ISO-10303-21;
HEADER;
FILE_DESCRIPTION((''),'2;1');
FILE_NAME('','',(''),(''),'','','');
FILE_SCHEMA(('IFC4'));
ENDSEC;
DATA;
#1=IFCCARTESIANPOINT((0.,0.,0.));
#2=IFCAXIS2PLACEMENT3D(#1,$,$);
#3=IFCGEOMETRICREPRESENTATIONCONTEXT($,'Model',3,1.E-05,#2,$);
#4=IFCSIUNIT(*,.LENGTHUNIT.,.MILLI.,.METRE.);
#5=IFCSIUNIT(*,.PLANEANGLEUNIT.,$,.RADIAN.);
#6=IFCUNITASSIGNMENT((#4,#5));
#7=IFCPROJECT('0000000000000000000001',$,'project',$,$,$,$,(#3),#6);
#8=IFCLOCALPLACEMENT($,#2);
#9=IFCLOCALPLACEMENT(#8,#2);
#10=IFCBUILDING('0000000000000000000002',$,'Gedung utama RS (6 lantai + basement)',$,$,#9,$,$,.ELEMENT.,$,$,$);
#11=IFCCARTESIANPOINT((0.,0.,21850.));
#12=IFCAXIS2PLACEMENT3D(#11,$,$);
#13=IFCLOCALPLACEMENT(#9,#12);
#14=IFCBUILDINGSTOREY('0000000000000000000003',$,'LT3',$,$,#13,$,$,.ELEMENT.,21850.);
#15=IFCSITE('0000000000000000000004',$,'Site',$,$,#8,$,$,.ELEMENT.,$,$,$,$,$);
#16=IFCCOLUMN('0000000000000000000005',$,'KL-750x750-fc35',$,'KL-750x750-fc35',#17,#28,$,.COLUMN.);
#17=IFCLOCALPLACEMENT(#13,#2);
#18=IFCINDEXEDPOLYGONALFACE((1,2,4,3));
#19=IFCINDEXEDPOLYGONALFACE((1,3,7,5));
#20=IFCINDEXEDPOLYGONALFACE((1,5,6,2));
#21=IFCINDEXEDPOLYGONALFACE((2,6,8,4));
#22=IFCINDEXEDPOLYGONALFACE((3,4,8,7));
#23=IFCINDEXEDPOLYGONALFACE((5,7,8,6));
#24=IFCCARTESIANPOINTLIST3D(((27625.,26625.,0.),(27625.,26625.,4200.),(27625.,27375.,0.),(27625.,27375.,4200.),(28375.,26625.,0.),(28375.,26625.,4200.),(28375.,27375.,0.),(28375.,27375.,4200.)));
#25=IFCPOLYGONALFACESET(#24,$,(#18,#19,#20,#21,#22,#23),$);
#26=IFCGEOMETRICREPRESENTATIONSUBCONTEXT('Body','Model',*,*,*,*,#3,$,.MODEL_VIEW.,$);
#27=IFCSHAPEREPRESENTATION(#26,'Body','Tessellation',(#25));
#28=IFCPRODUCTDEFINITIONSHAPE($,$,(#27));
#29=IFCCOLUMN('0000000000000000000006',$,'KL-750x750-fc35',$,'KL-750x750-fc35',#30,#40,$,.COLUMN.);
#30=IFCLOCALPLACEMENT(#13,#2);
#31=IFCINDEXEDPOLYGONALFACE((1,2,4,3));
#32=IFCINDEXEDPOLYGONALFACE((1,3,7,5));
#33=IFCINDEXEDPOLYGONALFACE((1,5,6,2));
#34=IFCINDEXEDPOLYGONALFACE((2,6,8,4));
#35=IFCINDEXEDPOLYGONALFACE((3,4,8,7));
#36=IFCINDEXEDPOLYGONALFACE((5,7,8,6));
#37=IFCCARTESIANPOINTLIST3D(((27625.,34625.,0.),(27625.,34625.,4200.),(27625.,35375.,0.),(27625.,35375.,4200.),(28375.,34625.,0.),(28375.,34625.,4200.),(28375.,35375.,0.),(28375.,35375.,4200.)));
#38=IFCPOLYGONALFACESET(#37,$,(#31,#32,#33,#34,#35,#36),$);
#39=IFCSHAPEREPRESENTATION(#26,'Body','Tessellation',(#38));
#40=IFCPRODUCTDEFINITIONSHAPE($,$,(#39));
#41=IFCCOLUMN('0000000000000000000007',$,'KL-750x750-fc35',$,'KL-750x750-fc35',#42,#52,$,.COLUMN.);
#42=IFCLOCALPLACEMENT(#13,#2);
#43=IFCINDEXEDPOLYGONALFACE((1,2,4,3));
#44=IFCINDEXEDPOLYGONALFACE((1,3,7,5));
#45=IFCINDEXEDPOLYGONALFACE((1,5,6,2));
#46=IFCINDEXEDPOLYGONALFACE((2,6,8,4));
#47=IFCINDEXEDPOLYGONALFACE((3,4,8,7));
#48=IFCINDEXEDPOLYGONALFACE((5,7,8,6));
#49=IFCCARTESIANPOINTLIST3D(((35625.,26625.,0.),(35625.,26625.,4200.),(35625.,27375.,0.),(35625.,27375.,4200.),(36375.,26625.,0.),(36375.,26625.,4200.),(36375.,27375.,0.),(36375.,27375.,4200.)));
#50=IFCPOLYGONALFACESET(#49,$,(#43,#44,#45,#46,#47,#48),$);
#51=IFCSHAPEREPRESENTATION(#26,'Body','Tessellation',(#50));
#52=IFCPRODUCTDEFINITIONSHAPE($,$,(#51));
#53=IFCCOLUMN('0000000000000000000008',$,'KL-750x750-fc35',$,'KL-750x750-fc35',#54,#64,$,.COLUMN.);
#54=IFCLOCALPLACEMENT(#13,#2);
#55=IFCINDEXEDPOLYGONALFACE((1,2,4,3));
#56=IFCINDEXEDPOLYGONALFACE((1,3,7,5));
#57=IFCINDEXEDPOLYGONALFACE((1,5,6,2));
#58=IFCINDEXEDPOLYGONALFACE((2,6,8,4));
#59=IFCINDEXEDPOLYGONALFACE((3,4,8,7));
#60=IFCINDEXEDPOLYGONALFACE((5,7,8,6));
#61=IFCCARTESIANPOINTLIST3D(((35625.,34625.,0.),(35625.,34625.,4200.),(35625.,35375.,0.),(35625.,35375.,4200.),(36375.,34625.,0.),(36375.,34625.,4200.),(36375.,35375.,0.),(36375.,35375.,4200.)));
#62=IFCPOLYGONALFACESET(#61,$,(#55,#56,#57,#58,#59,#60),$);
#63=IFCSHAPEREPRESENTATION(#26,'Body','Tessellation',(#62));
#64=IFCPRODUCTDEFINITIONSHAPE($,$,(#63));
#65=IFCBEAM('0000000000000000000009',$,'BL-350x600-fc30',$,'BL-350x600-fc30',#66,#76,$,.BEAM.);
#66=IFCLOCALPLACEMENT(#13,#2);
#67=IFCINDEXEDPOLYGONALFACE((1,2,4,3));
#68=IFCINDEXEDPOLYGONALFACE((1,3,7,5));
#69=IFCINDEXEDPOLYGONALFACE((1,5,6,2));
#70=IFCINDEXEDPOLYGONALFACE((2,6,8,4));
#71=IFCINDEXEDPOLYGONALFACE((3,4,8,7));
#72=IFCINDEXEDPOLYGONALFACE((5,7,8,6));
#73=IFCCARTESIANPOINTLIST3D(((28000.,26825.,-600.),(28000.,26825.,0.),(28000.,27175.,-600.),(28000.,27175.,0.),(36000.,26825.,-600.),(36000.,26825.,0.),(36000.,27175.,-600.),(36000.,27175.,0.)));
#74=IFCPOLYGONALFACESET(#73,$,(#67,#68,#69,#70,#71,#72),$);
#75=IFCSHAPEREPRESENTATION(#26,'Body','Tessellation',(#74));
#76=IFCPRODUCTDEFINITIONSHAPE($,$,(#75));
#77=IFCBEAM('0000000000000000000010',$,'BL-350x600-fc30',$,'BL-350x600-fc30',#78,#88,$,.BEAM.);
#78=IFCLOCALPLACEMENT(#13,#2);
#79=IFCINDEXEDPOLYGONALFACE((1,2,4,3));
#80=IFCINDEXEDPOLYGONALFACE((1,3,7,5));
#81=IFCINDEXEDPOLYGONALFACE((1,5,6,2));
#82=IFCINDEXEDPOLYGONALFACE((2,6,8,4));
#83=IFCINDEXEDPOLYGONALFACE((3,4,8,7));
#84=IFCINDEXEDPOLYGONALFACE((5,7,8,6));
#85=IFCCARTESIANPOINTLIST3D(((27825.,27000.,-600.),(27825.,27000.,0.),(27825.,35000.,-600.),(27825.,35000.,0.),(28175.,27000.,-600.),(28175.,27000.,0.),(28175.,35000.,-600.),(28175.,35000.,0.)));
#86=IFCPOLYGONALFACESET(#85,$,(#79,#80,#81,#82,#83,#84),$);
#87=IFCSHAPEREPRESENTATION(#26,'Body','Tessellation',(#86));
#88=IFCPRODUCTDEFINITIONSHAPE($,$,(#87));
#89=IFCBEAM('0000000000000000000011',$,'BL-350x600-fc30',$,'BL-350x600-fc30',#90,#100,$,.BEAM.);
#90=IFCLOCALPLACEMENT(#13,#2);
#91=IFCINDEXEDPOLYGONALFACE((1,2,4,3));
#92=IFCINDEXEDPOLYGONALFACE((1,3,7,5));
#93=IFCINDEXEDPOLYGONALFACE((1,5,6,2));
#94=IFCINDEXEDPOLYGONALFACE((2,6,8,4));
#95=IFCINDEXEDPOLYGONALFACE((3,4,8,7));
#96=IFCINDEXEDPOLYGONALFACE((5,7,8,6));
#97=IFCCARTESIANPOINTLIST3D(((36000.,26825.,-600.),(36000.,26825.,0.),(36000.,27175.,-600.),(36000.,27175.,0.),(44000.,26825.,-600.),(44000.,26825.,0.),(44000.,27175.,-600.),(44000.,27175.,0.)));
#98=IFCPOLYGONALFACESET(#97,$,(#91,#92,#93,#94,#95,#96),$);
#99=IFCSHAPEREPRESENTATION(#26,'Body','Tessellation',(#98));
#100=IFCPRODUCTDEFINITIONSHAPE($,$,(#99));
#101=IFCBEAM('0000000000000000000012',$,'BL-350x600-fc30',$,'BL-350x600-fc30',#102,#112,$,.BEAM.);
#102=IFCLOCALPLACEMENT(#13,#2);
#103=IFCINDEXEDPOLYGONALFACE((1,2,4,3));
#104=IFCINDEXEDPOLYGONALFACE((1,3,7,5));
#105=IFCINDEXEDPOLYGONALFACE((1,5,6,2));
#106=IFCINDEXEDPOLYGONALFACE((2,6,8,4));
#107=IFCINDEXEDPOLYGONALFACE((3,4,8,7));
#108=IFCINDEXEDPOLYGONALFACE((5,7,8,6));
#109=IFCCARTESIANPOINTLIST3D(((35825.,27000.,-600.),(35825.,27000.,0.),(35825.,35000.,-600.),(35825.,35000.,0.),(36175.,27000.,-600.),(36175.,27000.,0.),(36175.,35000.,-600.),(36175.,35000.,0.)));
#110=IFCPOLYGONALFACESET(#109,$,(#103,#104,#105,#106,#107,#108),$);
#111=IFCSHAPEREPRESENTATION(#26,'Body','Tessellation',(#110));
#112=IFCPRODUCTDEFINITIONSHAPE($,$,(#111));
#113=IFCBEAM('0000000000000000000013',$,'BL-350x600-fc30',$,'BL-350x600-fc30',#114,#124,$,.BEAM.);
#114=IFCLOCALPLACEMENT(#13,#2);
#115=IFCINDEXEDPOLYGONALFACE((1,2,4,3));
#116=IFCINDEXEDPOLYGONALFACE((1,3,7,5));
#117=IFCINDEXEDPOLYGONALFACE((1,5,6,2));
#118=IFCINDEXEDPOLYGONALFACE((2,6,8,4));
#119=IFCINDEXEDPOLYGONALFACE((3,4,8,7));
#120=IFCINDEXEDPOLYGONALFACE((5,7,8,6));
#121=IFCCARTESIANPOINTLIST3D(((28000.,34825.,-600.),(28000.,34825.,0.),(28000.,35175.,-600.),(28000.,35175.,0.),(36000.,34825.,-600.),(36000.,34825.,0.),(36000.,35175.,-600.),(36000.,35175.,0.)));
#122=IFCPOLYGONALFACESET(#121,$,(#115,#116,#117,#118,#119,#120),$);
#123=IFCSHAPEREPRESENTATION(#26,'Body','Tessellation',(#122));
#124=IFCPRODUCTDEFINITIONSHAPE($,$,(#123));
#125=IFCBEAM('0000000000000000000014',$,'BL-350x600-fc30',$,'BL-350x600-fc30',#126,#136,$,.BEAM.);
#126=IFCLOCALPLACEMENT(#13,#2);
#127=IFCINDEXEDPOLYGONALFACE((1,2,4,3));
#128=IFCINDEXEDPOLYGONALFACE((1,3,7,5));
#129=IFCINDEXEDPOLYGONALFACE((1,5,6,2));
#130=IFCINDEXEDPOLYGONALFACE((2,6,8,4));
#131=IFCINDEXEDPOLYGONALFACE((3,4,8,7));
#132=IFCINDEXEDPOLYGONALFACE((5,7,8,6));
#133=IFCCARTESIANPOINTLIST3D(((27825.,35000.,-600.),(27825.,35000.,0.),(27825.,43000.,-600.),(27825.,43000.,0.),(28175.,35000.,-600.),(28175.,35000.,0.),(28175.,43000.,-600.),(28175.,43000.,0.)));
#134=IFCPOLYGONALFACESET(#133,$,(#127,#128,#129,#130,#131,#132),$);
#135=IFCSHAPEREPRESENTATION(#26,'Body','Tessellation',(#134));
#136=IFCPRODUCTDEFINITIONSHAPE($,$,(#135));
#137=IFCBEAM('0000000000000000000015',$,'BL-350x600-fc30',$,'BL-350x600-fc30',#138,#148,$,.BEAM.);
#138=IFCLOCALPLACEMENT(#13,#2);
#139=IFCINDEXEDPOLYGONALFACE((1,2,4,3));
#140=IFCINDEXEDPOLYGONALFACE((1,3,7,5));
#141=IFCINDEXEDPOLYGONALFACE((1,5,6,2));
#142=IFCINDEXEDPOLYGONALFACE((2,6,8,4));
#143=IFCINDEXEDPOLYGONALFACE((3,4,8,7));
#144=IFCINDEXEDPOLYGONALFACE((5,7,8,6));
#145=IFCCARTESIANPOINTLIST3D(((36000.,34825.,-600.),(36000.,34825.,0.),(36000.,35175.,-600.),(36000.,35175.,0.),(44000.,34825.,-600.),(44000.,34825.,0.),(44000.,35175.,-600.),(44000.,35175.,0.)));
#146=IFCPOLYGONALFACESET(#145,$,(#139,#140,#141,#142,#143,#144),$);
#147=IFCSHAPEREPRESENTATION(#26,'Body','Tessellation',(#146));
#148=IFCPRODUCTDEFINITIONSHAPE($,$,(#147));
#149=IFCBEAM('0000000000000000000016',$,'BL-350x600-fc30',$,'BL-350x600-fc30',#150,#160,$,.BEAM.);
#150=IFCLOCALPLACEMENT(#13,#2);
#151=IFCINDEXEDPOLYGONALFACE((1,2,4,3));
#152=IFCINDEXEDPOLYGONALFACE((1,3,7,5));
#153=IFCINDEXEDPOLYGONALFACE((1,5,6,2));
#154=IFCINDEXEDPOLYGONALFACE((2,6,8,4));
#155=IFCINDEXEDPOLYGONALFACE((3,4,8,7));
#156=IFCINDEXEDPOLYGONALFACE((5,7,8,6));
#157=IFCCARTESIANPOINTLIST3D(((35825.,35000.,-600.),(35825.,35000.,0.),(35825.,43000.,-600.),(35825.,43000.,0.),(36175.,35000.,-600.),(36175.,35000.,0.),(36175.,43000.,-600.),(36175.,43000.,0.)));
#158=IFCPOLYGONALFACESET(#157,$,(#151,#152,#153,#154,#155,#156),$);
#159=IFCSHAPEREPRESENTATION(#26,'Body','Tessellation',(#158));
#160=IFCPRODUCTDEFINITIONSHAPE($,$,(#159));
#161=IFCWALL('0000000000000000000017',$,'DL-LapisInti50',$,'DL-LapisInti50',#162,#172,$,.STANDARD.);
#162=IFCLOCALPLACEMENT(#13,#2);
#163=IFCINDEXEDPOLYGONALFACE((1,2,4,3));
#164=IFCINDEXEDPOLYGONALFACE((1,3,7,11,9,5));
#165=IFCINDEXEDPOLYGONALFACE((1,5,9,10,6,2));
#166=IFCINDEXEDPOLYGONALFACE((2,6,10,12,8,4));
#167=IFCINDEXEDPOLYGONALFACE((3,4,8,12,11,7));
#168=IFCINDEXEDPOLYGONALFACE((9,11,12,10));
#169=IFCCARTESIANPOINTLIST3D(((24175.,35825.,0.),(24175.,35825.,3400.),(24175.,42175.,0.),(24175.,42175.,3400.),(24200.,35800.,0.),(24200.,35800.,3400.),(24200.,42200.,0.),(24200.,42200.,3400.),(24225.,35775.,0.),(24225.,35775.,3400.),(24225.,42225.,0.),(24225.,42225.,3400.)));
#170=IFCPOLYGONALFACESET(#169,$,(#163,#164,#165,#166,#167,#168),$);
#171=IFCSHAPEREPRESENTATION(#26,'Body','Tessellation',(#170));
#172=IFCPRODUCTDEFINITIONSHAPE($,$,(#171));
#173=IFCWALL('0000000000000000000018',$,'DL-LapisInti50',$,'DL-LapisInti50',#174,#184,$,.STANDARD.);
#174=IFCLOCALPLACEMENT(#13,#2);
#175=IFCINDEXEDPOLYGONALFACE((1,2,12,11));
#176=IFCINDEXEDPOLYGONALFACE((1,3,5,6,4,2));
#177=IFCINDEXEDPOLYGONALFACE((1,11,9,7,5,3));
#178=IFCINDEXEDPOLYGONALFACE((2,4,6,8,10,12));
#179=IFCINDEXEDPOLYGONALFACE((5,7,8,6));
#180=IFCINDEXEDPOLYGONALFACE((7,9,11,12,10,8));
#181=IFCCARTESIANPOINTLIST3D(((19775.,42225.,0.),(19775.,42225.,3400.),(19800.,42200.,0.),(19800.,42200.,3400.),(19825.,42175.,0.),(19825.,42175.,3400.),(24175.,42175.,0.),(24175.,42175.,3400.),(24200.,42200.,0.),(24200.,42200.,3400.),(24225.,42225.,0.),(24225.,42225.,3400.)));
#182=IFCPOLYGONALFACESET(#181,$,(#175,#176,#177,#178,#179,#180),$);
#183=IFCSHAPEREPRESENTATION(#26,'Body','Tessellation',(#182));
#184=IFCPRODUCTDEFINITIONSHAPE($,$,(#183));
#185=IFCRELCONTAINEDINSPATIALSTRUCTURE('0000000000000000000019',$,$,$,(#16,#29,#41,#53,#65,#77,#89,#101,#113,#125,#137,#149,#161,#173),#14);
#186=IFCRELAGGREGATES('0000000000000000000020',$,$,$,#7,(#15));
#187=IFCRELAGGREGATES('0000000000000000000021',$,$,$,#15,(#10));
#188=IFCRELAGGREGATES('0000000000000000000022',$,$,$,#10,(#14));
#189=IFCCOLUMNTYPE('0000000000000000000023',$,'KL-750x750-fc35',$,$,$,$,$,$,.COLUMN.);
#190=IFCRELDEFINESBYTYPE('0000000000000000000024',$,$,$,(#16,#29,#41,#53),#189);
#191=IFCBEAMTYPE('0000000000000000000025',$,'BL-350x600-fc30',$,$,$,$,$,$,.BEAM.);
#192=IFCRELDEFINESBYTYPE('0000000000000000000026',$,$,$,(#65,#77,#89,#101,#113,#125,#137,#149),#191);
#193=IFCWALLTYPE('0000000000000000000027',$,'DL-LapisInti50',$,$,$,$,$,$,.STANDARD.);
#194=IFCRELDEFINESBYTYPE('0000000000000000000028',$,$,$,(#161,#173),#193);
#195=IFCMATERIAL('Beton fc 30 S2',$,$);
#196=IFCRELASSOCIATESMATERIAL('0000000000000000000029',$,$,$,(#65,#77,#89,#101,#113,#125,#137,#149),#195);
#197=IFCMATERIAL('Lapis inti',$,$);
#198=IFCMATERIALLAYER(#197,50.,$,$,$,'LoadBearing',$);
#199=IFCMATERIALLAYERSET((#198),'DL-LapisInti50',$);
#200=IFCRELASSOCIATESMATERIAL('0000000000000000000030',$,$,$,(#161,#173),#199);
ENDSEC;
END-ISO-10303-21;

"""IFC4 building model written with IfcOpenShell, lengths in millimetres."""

from ifc_helpers import new_model, si_unit, frame, origin, origin_2d, place, context, subcontext, project, spatial, polyline, rectangle, outline, extrude, material, layer, layer_set, layer_usage, material_profile, profile_set, profile_usage, type_object, element, save


model = new_model("IFC4")

# Units and contexts
model_context = context("Model", 3, precision=1e-05, world=origin())
body_context = subcontext(model_context, "Body", "Model", "MODEL_VIEW")
ifc_project = project(units=[si_unit("LENGTHUNIT", "METRE", prefix="MILLI"), si_unit("PLANEANGLEUNIT", "RADIAN")], contexts=[model_context])

# Site, building, storey
site_placement = place(None, origin())
site = spatial("IfcSite", under=ifc_project, at=site_placement, Name="Site", CompositionType="ELEMENT")
building_placement = place(site_placement, origin())
building = spatial("IfcBuilding", under=site, at=building_placement, Name="Gedung utama RS (6 lantai + basement)", CompositionType="ELEMENT")
storey_placement = place(building_placement, frame((0.0, 0.0, 21850.0)))
storey = spatial("IfcBuildingStorey", under=building, at=storey_placement, Name="LT3", CompositionType="ELEMENT", Elevation=21850.0)

# Columns
ifc_material_profile_1 = material_profile(None, rectangle(XDim=750.0, YDim=750.0, at=origin_2d()), Name="KL-750x750-fc35")
ifc_profile_set_1 = profile_set([ifc_material_profile_1], Name="KL-750x750-fc35")
ifc_profile_usage_1 = profile_usage(ifc_profile_set_1, cardinal=5)
column_type = type_object("IfcColumnType", Name="KL-750x750-fc35", PredefinedType="COLUMN")
for number, where, z_axis, x_axis, name in (
    (1, (28000.0, 27000.0, 0.0), (0.0, 0.0, 1.0), (1.0, 0.0, 0.0), "KL-750x750-fc35"),
    (2, (28000.0, 35000.0, 0.0), (0.0, 0.0, 1.0), (1.0, 0.0, 0.0), "KL-750x750-fc35"),
    (3, (36000.0, 27000.0, 0.0), (0.0, 0.0, 1.0), (1.0, 0.0, 0.0), "KL-750x750-fc35"),
    (4, (36000.0, 35000.0, 0.0), (0.0, 0.0, 1.0), (1.0, 0.0, 0.0), "KL-750x750-fc35"),
):
    element("IfcColumn", number, at=place(storey_placement, frame(where, z_axis=z_axis, x_axis=x_axis)), inside=storey, type_object=column_type, material=ifc_profile_usage_1, Name=name, ObjectType="KL-750x750-fc35", PredefinedType="COLUMN", context=body_context, shape_type="SweptSolid", body=[
        extrude(rectangle(XDim=750.0, YDim=750.0, at=origin_2d()), origin(), (0.0, 0.0, 1.0), 4200.0),
    ])

# Beams
ifc_material_1 = material(Name="Beton fc 30 S2")
ifc_material_profile_2 = material_profile(ifc_material_1, rectangle(XDim=350.0, YDim=600.0, at=origin_2d()), Name="BL-350x600-fc30")
ifc_profile_set_2 = profile_set([ifc_material_profile_2], Name="BL-350x600-fc30")
ifc_profile_usage_2 = profile_usage(ifc_profile_set_2, cardinal=8)
beam_type = type_object("IfcBeamType", Name="BL-350x600-fc30", PredefinedType="BEAM")
beam_1_placement = place(storey_placement, frame((28000.0, 27000.0, -300.0)))
element("IfcBeam", 5, at=beam_1_placement, inside=storey, type_object=beam_type, material=ifc_profile_usage_2, Name="BL-350x600-fc30", ObjectType="BL-350x600-fc30", PredefinedType="BEAM", context=body_context, shape_type="SweptSolid", body=[
    extrude(rectangle(XDim=350.0, YDim=600.0, at=origin_2d()), frame((0.0, 0.0, 0.0), z_axis=(1.0, 0.0, 0.0), x_axis=(0.0, 1.0, 0.0)), (0.0, 0.0, 1.0), 8000.0),
])
beam_2_placement = place(storey_placement, frame((28000.0, 27000.0, -300.0)))
element("IfcBeam", 6, at=beam_2_placement, inside=storey, type_object=beam_type, material=ifc_profile_usage_2, Name="BL-350x600-fc30", ObjectType="BL-350x600-fc30", PredefinedType="BEAM", context=body_context, shape_type="SweptSolid", body=[
    extrude(rectangle(XDim=350.0, YDim=600.0, at=origin_2d()), frame((0.0, 0.0, 0.0), z_axis=(0.0, 1.0, 0.0), x_axis=(-1.0, 0.0, 0.0)), (0.0, 0.0, 1.0), 8000.0),
])
beam_3_placement = place(storey_placement, frame((36000.0, 27000.0, -300.0)))
element("IfcBeam", 7, at=beam_3_placement, inside=storey, type_object=beam_type, material=ifc_profile_usage_2, Name="BL-350x600-fc30", ObjectType="BL-350x600-fc30", PredefinedType="BEAM", context=body_context, shape_type="SweptSolid", body=[
    extrude(rectangle(XDim=350.0, YDim=600.0, at=origin_2d()), frame((0.0, 0.0, 0.0), z_axis=(1.0, 0.0, 0.0), x_axis=(0.0, 1.0, 0.0)), (0.0, 0.0, 1.0), 8000.0),
])
beam_4_placement = place(storey_placement, frame((36000.0, 27000.0, -300.0)))
element("IfcBeam", 8, at=beam_4_placement, inside=storey, type_object=beam_type, material=ifc_profile_usage_2, Name="BL-350x600-fc30", ObjectType="BL-350x600-fc30", PredefinedType="BEAM", context=body_context, shape_type="SweptSolid", body=[
    extrude(rectangle(XDim=350.0, YDim=600.0, at=origin_2d()), frame((0.0, 0.0, 0.0), z_axis=(0.0, 1.0, 0.0), x_axis=(-1.0, 0.0, 0.0)), (0.0, 0.0, 1.0), 8000.0),
])
beam_5_placement = place(storey_placement, frame((28000.0, 35000.0, -300.0)))
element("IfcBeam", 9, at=beam_5_placement, inside=storey, type_object=beam_type, material=ifc_profile_usage_2, Name="BL-350x600-fc30", ObjectType="BL-350x600-fc30", PredefinedType="BEAM", context=body_context, shape_type="SweptSolid", body=[
    extrude(rectangle(XDim=350.0, YDim=600.0, at=origin_2d()), frame((0.0, 0.0, 0.0), z_axis=(1.0, 0.0, 0.0), x_axis=(0.0, 1.0, 0.0)), (0.0, 0.0, 1.0), 8000.0),
])
beam_6_placement = place(storey_placement, frame((28000.0, 35000.0, -300.0)))
element("IfcBeam", 10, at=beam_6_placement, inside=storey, type_object=beam_type, material=ifc_profile_usage_2, Name="BL-350x600-fc30", ObjectType="BL-350x600-fc30", PredefinedType="BEAM", context=body_context, shape_type="SweptSolid", body=[
    extrude(rectangle(XDim=350.0, YDim=600.0, at=origin_2d()), frame((0.0, 0.0, 0.0), z_axis=(0.0, 1.0, 0.0), x_axis=(-1.0, 0.0, 0.0)), (0.0, 0.0, 1.0), 8000.0),
])
beam_7_placement = place(storey_placement, frame((36000.0, 35000.0, -300.0)))
element("IfcBeam", 11, at=beam_7_placement, inside=storey, type_object=beam_type, material=ifc_profile_usage_2, Name="BL-350x600-fc30", ObjectType="BL-350x600-fc30", PredefinedType="BEAM", context=body_context, shape_type="SweptSolid", body=[
    extrude(rectangle(XDim=350.0, YDim=600.0, at=origin_2d()), frame((0.0, 0.0, 0.0), z_axis=(1.0, 0.0, 0.0), x_axis=(0.0, 1.0, 0.0)), (0.0, 0.0, 1.0), 8000.0),
])
beam_8_placement = place(storey_placement, frame((36000.0, 35000.0, -300.0)))
element("IfcBeam", 12, at=beam_8_placement, inside=storey, type_object=beam_type, material=ifc_profile_usage_2, Name="BL-350x600-fc30", ObjectType="BL-350x600-fc30", PredefinedType="BEAM", context=body_context, shape_type="SweptSolid", body=[
    extrude(rectangle(XDim=350.0, YDim=600.0, at=origin_2d()), frame((0.0, 0.0, 0.0), z_axis=(0.0, 1.0, 0.0), x_axis=(-1.0, 0.0, 0.0)), (0.0, 0.0, 1.0), 8000.0),
])

# Walls
ifc_material_2 = material(Name="Lapis inti")
ifc_layer_1 = layer(ifc_material_2, 50.0, Category="LoadBearing")
ifc_layer_set_1 = layer_set([ifc_layer_1], Name="DL-LapisInti50")
ifc_layer_usage_1 = layer_usage(ifc_layer_set_1, "AXIS2", "NEGATIVE", 25.0)
wall_type_1 = type_object("IfcWallType", Name="DL-LapisInti50", PredefinedType="STANDARD")
wall_1_placement = place(storey_placement, frame((24200.0, 35800.0, 0.0), z_axis=(0.0, 0.0, 1.0), x_axis=(0.0, 1.0, 0.0)))
element("IfcWall", 13, at=wall_1_placement, inside=storey, type_object=wall_type_1, material=ifc_layer_usage_1, Name="DL-LapisInti50", ObjectType="DL-LapisInti50", PredefinedType="STANDARD", context=body_context, shape_type="SweptSolid", body=[
    extrude(outline(polyline([(-25.0, -25.0), (0.0, 0.0), (25.0, 25.0), (6375.0, 25.0), (6400.0, 0.0), (6425.0, -25.0), (-25.0, -25.0)])), origin(), (0.0, 0.0, 1.0), 3400.0),
])
wall_2_placement = place(storey_placement, frame((24200.0, 42200.0, 0.0), z_axis=(0.0, 0.0, 1.0), x_axis=(-1.0, 0.0, 0.0)))
element("IfcWall", 14, at=wall_2_placement, inside=storey, type_object=wall_type_1, material=ifc_layer_usage_1, Name="DL-LapisInti50", ObjectType="DL-LapisInti50", PredefinedType="STANDARD", context=body_context, shape_type="SweptSolid", body=[
    extrude(outline(polyline([(-25.0, -25.0), (0.0, 0.0), (25.0, 25.0), (4375.0, 25.0), (4400.0, 0.0), (4425.0, -25.0), (-25.0, -25.0)])), origin(), (0.0, 0.0, 1.0), 3400.0),
])

save(model, "model.ifc")
